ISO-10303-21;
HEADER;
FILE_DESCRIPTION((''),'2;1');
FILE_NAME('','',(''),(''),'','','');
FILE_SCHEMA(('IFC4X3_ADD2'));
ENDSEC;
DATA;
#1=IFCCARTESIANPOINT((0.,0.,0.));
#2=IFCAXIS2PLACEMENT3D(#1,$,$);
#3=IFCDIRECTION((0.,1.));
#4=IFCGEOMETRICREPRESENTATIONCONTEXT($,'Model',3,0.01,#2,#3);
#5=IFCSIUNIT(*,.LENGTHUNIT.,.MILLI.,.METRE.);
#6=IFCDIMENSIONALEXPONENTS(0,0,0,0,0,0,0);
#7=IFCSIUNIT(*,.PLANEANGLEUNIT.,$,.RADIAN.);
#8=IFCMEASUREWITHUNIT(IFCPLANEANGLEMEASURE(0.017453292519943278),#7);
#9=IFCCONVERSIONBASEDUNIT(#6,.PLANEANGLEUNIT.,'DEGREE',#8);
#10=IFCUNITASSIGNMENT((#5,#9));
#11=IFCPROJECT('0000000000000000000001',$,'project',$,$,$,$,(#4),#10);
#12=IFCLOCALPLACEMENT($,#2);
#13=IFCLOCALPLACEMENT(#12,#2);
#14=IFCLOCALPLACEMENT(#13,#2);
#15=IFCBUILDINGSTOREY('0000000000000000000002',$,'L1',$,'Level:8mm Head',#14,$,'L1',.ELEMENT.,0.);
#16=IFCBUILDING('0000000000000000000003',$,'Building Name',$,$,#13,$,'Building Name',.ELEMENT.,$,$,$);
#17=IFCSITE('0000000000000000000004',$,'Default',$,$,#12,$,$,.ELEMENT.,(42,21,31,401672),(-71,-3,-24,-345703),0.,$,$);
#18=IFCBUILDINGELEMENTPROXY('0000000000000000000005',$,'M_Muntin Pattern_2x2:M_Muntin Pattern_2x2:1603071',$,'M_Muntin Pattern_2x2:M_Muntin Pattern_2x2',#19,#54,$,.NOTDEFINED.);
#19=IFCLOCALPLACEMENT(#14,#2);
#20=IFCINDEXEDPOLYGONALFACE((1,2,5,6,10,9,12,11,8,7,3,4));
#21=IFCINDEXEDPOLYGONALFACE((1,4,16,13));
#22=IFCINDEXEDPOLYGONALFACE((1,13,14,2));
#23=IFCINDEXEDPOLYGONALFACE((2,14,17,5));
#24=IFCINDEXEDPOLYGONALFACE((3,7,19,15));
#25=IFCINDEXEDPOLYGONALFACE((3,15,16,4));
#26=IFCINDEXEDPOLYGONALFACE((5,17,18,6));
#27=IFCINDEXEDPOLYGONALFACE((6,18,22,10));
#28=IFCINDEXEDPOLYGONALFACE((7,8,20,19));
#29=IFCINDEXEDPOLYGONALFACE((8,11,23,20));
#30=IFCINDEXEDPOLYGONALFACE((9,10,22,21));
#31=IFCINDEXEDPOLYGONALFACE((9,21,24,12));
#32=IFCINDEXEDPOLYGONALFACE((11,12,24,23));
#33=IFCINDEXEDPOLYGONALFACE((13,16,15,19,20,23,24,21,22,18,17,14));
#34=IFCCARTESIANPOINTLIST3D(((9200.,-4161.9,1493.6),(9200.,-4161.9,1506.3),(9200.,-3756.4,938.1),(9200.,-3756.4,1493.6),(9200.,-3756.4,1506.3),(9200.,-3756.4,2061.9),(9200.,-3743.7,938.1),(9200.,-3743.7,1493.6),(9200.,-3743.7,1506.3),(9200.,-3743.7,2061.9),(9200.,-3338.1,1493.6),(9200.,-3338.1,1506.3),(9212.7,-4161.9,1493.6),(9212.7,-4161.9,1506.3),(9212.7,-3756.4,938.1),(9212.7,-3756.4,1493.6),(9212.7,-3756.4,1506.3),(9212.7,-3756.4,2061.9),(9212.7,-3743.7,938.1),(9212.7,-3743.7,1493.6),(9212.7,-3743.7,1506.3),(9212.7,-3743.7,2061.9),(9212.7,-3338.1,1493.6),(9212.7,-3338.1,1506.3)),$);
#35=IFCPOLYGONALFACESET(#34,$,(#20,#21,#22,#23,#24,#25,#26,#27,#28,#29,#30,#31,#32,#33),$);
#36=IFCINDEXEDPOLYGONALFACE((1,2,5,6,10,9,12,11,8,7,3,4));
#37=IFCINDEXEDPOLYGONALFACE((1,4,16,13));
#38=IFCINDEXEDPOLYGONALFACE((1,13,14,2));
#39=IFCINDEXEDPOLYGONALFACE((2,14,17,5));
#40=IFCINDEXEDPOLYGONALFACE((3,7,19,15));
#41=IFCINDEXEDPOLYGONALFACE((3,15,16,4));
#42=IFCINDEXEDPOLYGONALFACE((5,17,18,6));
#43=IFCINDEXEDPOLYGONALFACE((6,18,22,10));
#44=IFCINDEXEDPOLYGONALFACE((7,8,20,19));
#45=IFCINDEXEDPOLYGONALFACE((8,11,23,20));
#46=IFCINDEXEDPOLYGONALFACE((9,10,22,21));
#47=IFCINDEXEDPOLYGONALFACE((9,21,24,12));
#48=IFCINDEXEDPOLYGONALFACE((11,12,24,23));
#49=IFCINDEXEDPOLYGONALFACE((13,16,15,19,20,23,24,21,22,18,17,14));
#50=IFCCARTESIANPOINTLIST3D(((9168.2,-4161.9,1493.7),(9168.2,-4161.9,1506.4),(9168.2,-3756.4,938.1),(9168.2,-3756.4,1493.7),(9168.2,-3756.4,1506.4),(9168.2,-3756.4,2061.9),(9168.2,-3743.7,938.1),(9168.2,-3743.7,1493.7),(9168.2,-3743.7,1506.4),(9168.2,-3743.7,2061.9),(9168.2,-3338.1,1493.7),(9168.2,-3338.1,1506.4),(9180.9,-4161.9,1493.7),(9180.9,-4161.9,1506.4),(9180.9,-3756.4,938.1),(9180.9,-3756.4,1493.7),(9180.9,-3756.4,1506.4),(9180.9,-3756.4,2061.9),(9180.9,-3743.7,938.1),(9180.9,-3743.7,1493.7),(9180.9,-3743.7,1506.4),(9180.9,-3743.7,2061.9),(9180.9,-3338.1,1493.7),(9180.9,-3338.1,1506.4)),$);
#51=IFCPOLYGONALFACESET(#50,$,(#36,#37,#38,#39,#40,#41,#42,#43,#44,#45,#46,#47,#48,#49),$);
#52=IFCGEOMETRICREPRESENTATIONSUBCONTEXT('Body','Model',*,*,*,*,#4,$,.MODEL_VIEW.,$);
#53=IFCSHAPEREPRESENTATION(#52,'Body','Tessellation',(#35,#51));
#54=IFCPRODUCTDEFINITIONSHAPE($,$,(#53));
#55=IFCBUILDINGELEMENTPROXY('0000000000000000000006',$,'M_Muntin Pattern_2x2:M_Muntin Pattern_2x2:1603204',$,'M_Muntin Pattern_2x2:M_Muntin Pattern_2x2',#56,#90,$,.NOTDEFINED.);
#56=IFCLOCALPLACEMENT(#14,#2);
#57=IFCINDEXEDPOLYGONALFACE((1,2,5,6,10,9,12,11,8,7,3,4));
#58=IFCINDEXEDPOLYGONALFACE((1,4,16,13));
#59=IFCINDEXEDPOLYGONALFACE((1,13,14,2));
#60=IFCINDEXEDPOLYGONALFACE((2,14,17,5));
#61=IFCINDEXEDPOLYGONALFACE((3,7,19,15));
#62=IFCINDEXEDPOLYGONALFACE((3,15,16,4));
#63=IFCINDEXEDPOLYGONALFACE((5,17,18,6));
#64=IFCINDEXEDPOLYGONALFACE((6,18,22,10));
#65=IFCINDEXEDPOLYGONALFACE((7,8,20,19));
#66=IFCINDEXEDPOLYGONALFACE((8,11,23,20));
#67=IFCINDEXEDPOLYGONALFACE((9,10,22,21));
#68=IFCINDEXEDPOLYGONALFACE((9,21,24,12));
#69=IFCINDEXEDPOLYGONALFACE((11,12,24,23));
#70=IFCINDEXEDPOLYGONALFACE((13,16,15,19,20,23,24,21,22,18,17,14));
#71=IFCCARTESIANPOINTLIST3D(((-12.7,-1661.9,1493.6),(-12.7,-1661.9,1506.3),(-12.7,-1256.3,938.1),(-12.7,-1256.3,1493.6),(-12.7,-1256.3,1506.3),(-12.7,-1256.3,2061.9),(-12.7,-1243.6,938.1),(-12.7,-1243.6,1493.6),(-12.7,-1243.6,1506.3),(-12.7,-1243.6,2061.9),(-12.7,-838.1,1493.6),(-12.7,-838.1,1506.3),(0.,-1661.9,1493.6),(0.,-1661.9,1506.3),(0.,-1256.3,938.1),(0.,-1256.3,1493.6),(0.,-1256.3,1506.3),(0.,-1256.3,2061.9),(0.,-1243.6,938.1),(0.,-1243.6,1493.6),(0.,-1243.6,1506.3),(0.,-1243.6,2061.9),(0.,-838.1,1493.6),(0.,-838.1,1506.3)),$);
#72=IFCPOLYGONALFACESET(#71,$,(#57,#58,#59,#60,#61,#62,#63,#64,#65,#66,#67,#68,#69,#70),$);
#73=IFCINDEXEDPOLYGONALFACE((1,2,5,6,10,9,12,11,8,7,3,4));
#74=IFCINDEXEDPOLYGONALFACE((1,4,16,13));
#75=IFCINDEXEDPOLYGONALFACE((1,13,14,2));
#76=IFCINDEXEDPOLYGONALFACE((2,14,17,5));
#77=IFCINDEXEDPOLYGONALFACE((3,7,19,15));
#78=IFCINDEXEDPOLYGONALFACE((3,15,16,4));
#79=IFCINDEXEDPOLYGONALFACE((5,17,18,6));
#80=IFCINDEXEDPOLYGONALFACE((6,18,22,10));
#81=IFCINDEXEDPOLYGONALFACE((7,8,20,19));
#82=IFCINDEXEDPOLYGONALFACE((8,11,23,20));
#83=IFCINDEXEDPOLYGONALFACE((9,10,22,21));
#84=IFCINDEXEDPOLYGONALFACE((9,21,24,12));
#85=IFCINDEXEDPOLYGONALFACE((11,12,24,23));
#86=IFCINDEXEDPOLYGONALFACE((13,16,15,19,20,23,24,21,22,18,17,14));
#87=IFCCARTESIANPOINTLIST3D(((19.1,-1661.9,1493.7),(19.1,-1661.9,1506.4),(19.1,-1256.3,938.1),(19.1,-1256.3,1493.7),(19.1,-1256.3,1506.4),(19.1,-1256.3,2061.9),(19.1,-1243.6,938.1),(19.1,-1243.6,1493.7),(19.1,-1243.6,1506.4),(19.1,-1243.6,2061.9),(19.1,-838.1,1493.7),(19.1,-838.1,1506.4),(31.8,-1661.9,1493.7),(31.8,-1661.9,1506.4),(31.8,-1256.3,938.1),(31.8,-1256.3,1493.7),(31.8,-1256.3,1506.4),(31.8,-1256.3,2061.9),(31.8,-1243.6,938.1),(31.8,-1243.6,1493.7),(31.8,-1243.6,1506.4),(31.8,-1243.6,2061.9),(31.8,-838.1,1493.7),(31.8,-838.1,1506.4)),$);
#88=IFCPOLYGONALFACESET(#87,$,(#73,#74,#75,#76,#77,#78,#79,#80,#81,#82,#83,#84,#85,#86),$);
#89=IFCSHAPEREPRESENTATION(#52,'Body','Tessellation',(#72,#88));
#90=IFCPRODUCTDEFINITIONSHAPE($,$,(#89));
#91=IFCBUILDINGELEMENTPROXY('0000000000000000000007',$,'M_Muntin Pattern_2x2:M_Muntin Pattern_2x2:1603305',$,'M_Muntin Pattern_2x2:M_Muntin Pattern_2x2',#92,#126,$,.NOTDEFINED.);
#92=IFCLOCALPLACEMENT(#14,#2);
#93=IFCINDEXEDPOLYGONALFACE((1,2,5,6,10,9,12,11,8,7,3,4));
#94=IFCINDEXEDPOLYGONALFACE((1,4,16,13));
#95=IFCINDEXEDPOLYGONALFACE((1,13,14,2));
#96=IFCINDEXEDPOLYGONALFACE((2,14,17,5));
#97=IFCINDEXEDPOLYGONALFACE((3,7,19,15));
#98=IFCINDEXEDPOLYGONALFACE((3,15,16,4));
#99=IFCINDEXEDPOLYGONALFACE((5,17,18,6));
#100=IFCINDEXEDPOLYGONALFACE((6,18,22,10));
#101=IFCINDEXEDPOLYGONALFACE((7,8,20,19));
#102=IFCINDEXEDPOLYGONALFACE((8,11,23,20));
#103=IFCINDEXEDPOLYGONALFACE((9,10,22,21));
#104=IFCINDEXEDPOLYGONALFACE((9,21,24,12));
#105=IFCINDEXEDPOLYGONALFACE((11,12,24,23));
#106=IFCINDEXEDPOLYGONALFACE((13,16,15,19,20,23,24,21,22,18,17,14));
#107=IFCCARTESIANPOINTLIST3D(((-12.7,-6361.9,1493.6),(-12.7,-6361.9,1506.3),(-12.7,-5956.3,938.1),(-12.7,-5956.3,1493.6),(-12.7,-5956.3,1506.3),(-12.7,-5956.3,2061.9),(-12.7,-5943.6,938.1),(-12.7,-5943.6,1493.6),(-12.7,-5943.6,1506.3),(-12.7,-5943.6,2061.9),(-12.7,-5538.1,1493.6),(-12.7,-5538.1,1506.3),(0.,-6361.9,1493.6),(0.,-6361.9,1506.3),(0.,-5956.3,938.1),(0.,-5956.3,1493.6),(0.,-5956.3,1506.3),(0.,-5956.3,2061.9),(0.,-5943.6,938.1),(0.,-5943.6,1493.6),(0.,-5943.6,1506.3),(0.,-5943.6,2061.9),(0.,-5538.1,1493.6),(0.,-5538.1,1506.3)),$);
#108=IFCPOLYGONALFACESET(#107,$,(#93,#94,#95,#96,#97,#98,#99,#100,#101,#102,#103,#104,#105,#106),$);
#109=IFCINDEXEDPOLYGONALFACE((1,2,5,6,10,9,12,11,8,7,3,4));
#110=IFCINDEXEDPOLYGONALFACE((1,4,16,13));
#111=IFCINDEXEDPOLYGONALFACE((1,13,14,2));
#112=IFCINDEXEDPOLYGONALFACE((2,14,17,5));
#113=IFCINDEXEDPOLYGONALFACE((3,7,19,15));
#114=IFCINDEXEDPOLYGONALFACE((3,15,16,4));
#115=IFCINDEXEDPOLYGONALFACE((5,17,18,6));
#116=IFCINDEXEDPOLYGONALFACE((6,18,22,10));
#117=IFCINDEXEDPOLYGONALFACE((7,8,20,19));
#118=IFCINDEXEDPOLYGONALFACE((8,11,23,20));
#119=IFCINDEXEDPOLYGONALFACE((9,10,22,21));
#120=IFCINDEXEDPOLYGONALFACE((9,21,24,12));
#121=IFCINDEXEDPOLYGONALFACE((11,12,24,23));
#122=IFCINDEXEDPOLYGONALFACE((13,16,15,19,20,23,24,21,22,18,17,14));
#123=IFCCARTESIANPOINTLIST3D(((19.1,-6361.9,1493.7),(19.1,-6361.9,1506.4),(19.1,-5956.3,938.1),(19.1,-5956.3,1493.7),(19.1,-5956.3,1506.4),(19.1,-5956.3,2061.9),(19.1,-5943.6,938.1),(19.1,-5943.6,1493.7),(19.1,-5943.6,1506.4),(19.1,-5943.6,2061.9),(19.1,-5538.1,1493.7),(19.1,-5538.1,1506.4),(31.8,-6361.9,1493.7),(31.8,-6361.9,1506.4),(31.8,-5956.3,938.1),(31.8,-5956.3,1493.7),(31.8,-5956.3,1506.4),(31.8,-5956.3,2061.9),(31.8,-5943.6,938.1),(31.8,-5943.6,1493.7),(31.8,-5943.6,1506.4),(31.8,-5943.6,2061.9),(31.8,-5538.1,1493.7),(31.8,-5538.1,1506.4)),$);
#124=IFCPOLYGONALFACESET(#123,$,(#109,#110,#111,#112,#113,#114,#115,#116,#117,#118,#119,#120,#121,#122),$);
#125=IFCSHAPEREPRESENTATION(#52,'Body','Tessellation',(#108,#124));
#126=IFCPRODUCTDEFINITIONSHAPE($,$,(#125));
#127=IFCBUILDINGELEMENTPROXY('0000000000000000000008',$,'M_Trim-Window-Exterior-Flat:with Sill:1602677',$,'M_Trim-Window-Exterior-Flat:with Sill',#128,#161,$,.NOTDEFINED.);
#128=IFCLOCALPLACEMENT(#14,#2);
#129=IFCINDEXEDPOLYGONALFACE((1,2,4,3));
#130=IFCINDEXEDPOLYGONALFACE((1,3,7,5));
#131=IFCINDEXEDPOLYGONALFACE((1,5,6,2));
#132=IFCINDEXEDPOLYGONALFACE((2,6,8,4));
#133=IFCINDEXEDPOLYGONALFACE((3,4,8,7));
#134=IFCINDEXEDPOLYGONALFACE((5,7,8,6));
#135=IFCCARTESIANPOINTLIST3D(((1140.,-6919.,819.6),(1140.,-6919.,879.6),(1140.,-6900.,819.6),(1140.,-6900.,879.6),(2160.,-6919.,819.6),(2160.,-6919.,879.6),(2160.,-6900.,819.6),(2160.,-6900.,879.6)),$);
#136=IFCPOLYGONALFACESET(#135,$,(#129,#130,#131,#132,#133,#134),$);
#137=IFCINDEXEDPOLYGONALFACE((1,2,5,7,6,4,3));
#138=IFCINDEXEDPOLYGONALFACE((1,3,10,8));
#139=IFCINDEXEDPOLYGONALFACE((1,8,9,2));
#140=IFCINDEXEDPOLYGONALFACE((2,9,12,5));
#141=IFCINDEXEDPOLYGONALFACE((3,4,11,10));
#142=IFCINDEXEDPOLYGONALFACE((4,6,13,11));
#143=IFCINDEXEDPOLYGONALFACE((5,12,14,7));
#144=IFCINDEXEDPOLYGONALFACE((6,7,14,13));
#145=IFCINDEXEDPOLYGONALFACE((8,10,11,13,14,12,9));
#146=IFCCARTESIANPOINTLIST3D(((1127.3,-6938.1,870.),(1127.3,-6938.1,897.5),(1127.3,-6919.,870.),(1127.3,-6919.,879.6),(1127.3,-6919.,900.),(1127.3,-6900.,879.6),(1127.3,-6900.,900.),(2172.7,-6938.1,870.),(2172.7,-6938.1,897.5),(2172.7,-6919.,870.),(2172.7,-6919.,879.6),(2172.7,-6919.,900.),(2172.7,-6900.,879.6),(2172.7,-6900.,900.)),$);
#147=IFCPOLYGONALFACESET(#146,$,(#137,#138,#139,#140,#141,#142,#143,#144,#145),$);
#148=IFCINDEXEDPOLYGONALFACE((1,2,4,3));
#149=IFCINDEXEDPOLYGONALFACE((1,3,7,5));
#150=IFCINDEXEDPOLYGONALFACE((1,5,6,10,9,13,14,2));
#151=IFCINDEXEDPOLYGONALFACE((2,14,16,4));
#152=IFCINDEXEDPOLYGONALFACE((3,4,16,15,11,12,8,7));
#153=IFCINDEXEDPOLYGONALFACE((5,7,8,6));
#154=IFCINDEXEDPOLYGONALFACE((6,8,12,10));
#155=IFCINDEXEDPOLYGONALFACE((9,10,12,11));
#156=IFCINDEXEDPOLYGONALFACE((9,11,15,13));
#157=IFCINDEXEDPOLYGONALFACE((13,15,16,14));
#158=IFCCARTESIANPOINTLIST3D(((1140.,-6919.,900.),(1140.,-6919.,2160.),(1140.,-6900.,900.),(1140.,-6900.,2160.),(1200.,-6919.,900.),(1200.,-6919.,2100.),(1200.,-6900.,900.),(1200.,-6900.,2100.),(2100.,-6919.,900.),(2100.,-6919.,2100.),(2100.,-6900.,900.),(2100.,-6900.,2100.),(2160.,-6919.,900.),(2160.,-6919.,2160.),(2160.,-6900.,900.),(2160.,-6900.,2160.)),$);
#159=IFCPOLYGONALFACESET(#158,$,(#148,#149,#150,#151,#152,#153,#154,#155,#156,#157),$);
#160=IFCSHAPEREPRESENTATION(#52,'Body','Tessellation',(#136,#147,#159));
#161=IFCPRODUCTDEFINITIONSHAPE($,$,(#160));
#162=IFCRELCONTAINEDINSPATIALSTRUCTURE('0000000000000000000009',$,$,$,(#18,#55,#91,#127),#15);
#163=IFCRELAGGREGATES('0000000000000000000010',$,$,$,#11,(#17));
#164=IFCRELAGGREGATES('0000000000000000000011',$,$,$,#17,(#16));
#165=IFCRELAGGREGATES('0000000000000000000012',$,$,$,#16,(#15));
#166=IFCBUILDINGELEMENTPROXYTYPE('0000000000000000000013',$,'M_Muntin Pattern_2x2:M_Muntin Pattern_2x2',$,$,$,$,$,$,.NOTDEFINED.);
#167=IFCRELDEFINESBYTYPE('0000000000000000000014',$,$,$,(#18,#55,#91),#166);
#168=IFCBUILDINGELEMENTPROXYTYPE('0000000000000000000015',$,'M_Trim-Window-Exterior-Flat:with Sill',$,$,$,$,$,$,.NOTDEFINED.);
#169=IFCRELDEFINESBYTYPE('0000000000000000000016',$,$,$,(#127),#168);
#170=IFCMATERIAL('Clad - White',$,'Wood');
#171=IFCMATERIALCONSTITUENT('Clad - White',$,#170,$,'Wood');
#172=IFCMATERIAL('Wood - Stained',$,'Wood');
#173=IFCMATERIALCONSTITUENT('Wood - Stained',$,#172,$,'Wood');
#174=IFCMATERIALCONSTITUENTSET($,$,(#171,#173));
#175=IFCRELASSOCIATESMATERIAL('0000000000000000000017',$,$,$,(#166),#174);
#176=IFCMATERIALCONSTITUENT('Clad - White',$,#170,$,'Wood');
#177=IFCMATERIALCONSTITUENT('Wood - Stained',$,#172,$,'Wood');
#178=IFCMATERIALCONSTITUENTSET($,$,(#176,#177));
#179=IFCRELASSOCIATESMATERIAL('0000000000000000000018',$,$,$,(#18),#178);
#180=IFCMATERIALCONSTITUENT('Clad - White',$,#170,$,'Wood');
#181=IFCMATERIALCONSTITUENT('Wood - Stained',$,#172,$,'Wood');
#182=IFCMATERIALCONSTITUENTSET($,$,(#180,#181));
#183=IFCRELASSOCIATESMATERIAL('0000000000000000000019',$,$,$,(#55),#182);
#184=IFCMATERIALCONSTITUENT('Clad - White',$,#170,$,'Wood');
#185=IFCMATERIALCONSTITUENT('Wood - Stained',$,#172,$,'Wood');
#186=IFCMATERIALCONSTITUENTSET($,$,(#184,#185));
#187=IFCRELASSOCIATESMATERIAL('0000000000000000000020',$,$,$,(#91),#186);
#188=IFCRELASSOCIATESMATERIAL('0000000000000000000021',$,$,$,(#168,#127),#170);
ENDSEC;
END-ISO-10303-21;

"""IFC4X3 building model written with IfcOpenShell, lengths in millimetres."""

from ifc_helpers import new_model, entity, si_unit, converted_unit, direction, frame, frame_2d, origin, place, context, subcontext, project, spatial, polyline, rectangle, outline, extrude, source, transform, mapped, material, constituent, constituent_set, type_object, type_shapes, element, save


model = new_model("IFC4X3")

# Units and contexts
model_context = context("Model", 3, precision=0.01, world=origin(), true_north=direction((0.0, 1.0)))
body_context = subcontext(model_context, "Body", "Model", "MODEL_VIEW")
ifc_project = project(units=[si_unit("LENGTHUNIT", "METRE", prefix="MILLI"), converted_unit("PLANEANGLEUNIT", "DEGREE", entity("IfcPlaneAngleMeasure", 0.017453292519943278), si_unit("PLANEANGLEUNIT", "RADIAN"), dimensions=[0, 0, 0, 0, 0, 0, 0])], contexts=[model_context])

# Site, building, storey
site_placement = place(None, origin())
site = spatial("IfcSite", under=ifc_project, at=site_placement, Name="Default", CompositionType="ELEMENT", RefLatitude=(42, 21, 31, 401672), RefLongitude=(-71, -3, -24, -345703), RefElevation=0.0)
building_placement = place(site_placement, origin())
building = spatial("IfcBuilding", under=site, at=building_placement, Name="Building Name", LongName="Building Name", CompositionType="ELEMENT")
storey_placement = place(building_placement, origin())
storey = spatial("IfcBuildingStorey", under=building, at=storey_placement, Name="L1", ObjectType="Level:8mm Head", LongName="L1", CompositionType="ELEMENT", Elevation=0.0)

# Building element proxies
ifc_material_1 = material(Name="Clad - White", Category="Wood")
ifc_material_2 = material(Name="Wood - Stained", Category="Wood")
ifc_constituent_1 = constituent(ifc_material_1, Name="Clad - White", Category="Wood")
ifc_constituent_2 = constituent(ifc_material_2, Name="Wood - Stained", Category="Wood")
ifc_constituent_set_1 = constituent_set(constituents=[ifc_constituent_1, ifc_constituent_2])
building_element_proxy_type_1 = type_object("IfcBuildingElementProxyType", Name="M_Muntin Pattern_2x2:M_Muntin Pattern_2x2", PredefinedType="NOTDEFINED", material=ifc_constituent_set_1)
shared_shape_1 = source(origin(), body_context, "Body", "SweptSolid", [
    extrude(outline(polyline([(6.4, -6.4), (561.9, -6.4), (561.9, 6.3), (6.4, 6.3), (6.4, 411.9), (-6.3, 411.9), (-6.3, 6.3), (-561.9, 6.3), (-561.9, -6.4), (-6.3, -6.4), (-6.3, -411.9), (6.4, -411.9), (6.4, -6.4)])), frame((0.0, -22.2, 561.9), z_axis=(0.0, 1.0, 0.0), x_axis=(0.0, 0.0, 1.0)), (0.0, 0.0, 1.0), 12.7),
    extrude(outline(polyline([(6.4, -6.4), (561.9, -6.4), (561.9, 6.3), (6.4, 6.3), (6.4, 411.9), (-6.3, 411.9), (-6.3, 6.3), (-561.9, 6.3), (-561.9, -6.4), (-6.3, -6.4), (-6.3, -411.9), (6.4, -411.9), (6.4, -6.4)])), frame((0.0, 9.5, 561.9), z_axis=(0.0, 1.0, 0.0), x_axis=(0.0, 0.0, 1.0)), (0.0, 0.0, 1.0), 12.7),
])
type_shapes(building_element_proxy_type_1, [shared_shape_1])
ifc_constituent_3 = constituent(ifc_material_1, Name="Clad - White", Category="Wood")
ifc_constituent_4 = constituent(ifc_material_2, Name="Wood - Stained", Category="Wood")
ifc_constituent_set_2 = constituent_set(constituents=[ifc_constituent_3, ifc_constituent_4])
proxy_1_placement = place(storey_placement, frame((9190.5, -3750.0, 938.1), z_axis=(0.0, 0.0, 1.0), x_axis=(0.0, 1.0, 0.0)))
element("IfcBuildingElementProxy", 1, at=proxy_1_placement, inside=storey, type_object=building_element_proxy_type_1, material=ifc_constituent_set_2, Name="M_Muntin Pattern_2x2:M_Muntin Pattern_2x2:1603071", ObjectType="M_Muntin Pattern_2x2:M_Muntin Pattern_2x2", PredefinedType="NOTDEFINED", context=body_context, shape_type="MappedRepresentation", body=[
    mapped(shared_shape_1, transform((0.0, 0.0, 0.0), scale=1.0)),
])
ifc_constituent_5 = constituent(ifc_material_1, Name="Clad - White", Category="Wood")
ifc_constituent_6 = constituent(ifc_material_2, Name="Wood - Stained", Category="Wood")
ifc_constituent_set_3 = constituent_set(constituents=[ifc_constituent_5, ifc_constituent_6])
proxy_2_placement = place(storey_placement, frame((9.5, -1250.0, 938.1), z_axis=(0.0, 0.0, 1.0), x_axis=(0.0, -1.0, 0.0)))
element("IfcBuildingElementProxy", 2, at=proxy_2_placement, inside=storey, type_object=building_element_proxy_type_1, material=ifc_constituent_set_3, Name="M_Muntin Pattern_2x2:M_Muntin Pattern_2x2:1603204", ObjectType="M_Muntin Pattern_2x2:M_Muntin Pattern_2x2", PredefinedType="NOTDEFINED", context=body_context, shape_type="MappedRepresentation", body=[
    mapped(shared_shape_1, transform((0.0, 0.0, 0.0), scale=1.0)),
])
ifc_constituent_7 = constituent(ifc_material_1, Name="Clad - White", Category="Wood")
ifc_constituent_8 = constituent(ifc_material_2, Name="Wood - Stained", Category="Wood")
ifc_constituent_set_4 = constituent_set(constituents=[ifc_constituent_7, ifc_constituent_8])
proxy_3_placement = place(storey_placement, frame((9.5, -5950.0, 938.1), z_axis=(0.0, 0.0, 1.0), x_axis=(0.0, -1.0, 0.0)))
element("IfcBuildingElementProxy", 3, at=proxy_3_placement, inside=storey, type_object=building_element_proxy_type_1, material=ifc_constituent_set_4, Name="M_Muntin Pattern_2x2:M_Muntin Pattern_2x2:1603305", ObjectType="M_Muntin Pattern_2x2:M_Muntin Pattern_2x2", PredefinedType="NOTDEFINED", context=body_context, shape_type="MappedRepresentation", body=[
    mapped(shared_shape_1, transform((0.0, 0.0, 0.0), scale=1.0)),
])
building_element_proxy_type_2 = type_object("IfcBuildingElementProxyType", Name="M_Trim-Window-Exterior-Flat:with Sill", PredefinedType="NOTDEFINED", material=ifc_material_1)
shared_shape_2 = source(origin(), body_context, "Body", "SweptSolid", [
    extrude(rectangle(XDim=1020.0, YDim=60.0, at=frame_2d((0.0, 0.0), x_axis=(1.0, 0.0))), frame((0.0, -1250.4, 0.0), z_axis=(0.0, 0.0, 1.0), x_axis=(-1.0, 0.0, 0.0)), (0.0, 0.0, 1.0), 19.0),
    extrude(outline(polyline([(-19.0, -15.2), (0.0, -15.2), (0.0, -5.7), (19.0, -5.7), (19.0, 14.8), (0.0, 14.8), (-19.0, 12.3), (-19.0, -15.2)])), frame((-522.7, -1214.8, 19.0), z_axis=(1.0, 0.0, 0.0), x_axis=(0.0, 0.0, -1.0)), (0.0, 0.0, 1.0), 1045.4),
    extrude(outline(polyline([(-645.0, -510.0), (615.0, -510.0), (615.0, -450.0), (-585.0, -450.0), (-585.0, 450.0), (615.0, 450.0), (615.0, 510.0), (-645.0, 510.0), (-645.0, -510.0)])), frame((0.0, -585.0, 0.0), z_axis=(0.0, 0.0, 1.0), x_axis=(0.0, -1.0, 0.0)), (0.0, 0.0, 1.0), 19.0),
])
type_shapes(building_element_proxy_type_2, [shared_shape_2])
for number, where, z_axis, x_axis, name in (
    (4, (1650.0, -6900.0, 2100.0), (0.0, -1.0, 0.0), (1.0, 0.0, 0.0), "M_Trim-Window-Exterior-Flat:with Sill:1602677"),
):
    element("IfcBuildingElementProxy", number, at=place(storey_placement, frame(where, z_axis=z_axis, x_axis=x_axis)), inside=storey, type_object=building_element_proxy_type_2, material=ifc_material_1, Name=name, ObjectType="M_Trim-Window-Exterior-Flat:with Sill", PredefinedType="NOTDEFINED", context=body_context, shape_type="MappedRepresentation", body=[
        mapped(shared_shape_2, transform((0.0, 0.0, 0.0), scale=1.0)),
    ])

save(model, "model.ifc")
